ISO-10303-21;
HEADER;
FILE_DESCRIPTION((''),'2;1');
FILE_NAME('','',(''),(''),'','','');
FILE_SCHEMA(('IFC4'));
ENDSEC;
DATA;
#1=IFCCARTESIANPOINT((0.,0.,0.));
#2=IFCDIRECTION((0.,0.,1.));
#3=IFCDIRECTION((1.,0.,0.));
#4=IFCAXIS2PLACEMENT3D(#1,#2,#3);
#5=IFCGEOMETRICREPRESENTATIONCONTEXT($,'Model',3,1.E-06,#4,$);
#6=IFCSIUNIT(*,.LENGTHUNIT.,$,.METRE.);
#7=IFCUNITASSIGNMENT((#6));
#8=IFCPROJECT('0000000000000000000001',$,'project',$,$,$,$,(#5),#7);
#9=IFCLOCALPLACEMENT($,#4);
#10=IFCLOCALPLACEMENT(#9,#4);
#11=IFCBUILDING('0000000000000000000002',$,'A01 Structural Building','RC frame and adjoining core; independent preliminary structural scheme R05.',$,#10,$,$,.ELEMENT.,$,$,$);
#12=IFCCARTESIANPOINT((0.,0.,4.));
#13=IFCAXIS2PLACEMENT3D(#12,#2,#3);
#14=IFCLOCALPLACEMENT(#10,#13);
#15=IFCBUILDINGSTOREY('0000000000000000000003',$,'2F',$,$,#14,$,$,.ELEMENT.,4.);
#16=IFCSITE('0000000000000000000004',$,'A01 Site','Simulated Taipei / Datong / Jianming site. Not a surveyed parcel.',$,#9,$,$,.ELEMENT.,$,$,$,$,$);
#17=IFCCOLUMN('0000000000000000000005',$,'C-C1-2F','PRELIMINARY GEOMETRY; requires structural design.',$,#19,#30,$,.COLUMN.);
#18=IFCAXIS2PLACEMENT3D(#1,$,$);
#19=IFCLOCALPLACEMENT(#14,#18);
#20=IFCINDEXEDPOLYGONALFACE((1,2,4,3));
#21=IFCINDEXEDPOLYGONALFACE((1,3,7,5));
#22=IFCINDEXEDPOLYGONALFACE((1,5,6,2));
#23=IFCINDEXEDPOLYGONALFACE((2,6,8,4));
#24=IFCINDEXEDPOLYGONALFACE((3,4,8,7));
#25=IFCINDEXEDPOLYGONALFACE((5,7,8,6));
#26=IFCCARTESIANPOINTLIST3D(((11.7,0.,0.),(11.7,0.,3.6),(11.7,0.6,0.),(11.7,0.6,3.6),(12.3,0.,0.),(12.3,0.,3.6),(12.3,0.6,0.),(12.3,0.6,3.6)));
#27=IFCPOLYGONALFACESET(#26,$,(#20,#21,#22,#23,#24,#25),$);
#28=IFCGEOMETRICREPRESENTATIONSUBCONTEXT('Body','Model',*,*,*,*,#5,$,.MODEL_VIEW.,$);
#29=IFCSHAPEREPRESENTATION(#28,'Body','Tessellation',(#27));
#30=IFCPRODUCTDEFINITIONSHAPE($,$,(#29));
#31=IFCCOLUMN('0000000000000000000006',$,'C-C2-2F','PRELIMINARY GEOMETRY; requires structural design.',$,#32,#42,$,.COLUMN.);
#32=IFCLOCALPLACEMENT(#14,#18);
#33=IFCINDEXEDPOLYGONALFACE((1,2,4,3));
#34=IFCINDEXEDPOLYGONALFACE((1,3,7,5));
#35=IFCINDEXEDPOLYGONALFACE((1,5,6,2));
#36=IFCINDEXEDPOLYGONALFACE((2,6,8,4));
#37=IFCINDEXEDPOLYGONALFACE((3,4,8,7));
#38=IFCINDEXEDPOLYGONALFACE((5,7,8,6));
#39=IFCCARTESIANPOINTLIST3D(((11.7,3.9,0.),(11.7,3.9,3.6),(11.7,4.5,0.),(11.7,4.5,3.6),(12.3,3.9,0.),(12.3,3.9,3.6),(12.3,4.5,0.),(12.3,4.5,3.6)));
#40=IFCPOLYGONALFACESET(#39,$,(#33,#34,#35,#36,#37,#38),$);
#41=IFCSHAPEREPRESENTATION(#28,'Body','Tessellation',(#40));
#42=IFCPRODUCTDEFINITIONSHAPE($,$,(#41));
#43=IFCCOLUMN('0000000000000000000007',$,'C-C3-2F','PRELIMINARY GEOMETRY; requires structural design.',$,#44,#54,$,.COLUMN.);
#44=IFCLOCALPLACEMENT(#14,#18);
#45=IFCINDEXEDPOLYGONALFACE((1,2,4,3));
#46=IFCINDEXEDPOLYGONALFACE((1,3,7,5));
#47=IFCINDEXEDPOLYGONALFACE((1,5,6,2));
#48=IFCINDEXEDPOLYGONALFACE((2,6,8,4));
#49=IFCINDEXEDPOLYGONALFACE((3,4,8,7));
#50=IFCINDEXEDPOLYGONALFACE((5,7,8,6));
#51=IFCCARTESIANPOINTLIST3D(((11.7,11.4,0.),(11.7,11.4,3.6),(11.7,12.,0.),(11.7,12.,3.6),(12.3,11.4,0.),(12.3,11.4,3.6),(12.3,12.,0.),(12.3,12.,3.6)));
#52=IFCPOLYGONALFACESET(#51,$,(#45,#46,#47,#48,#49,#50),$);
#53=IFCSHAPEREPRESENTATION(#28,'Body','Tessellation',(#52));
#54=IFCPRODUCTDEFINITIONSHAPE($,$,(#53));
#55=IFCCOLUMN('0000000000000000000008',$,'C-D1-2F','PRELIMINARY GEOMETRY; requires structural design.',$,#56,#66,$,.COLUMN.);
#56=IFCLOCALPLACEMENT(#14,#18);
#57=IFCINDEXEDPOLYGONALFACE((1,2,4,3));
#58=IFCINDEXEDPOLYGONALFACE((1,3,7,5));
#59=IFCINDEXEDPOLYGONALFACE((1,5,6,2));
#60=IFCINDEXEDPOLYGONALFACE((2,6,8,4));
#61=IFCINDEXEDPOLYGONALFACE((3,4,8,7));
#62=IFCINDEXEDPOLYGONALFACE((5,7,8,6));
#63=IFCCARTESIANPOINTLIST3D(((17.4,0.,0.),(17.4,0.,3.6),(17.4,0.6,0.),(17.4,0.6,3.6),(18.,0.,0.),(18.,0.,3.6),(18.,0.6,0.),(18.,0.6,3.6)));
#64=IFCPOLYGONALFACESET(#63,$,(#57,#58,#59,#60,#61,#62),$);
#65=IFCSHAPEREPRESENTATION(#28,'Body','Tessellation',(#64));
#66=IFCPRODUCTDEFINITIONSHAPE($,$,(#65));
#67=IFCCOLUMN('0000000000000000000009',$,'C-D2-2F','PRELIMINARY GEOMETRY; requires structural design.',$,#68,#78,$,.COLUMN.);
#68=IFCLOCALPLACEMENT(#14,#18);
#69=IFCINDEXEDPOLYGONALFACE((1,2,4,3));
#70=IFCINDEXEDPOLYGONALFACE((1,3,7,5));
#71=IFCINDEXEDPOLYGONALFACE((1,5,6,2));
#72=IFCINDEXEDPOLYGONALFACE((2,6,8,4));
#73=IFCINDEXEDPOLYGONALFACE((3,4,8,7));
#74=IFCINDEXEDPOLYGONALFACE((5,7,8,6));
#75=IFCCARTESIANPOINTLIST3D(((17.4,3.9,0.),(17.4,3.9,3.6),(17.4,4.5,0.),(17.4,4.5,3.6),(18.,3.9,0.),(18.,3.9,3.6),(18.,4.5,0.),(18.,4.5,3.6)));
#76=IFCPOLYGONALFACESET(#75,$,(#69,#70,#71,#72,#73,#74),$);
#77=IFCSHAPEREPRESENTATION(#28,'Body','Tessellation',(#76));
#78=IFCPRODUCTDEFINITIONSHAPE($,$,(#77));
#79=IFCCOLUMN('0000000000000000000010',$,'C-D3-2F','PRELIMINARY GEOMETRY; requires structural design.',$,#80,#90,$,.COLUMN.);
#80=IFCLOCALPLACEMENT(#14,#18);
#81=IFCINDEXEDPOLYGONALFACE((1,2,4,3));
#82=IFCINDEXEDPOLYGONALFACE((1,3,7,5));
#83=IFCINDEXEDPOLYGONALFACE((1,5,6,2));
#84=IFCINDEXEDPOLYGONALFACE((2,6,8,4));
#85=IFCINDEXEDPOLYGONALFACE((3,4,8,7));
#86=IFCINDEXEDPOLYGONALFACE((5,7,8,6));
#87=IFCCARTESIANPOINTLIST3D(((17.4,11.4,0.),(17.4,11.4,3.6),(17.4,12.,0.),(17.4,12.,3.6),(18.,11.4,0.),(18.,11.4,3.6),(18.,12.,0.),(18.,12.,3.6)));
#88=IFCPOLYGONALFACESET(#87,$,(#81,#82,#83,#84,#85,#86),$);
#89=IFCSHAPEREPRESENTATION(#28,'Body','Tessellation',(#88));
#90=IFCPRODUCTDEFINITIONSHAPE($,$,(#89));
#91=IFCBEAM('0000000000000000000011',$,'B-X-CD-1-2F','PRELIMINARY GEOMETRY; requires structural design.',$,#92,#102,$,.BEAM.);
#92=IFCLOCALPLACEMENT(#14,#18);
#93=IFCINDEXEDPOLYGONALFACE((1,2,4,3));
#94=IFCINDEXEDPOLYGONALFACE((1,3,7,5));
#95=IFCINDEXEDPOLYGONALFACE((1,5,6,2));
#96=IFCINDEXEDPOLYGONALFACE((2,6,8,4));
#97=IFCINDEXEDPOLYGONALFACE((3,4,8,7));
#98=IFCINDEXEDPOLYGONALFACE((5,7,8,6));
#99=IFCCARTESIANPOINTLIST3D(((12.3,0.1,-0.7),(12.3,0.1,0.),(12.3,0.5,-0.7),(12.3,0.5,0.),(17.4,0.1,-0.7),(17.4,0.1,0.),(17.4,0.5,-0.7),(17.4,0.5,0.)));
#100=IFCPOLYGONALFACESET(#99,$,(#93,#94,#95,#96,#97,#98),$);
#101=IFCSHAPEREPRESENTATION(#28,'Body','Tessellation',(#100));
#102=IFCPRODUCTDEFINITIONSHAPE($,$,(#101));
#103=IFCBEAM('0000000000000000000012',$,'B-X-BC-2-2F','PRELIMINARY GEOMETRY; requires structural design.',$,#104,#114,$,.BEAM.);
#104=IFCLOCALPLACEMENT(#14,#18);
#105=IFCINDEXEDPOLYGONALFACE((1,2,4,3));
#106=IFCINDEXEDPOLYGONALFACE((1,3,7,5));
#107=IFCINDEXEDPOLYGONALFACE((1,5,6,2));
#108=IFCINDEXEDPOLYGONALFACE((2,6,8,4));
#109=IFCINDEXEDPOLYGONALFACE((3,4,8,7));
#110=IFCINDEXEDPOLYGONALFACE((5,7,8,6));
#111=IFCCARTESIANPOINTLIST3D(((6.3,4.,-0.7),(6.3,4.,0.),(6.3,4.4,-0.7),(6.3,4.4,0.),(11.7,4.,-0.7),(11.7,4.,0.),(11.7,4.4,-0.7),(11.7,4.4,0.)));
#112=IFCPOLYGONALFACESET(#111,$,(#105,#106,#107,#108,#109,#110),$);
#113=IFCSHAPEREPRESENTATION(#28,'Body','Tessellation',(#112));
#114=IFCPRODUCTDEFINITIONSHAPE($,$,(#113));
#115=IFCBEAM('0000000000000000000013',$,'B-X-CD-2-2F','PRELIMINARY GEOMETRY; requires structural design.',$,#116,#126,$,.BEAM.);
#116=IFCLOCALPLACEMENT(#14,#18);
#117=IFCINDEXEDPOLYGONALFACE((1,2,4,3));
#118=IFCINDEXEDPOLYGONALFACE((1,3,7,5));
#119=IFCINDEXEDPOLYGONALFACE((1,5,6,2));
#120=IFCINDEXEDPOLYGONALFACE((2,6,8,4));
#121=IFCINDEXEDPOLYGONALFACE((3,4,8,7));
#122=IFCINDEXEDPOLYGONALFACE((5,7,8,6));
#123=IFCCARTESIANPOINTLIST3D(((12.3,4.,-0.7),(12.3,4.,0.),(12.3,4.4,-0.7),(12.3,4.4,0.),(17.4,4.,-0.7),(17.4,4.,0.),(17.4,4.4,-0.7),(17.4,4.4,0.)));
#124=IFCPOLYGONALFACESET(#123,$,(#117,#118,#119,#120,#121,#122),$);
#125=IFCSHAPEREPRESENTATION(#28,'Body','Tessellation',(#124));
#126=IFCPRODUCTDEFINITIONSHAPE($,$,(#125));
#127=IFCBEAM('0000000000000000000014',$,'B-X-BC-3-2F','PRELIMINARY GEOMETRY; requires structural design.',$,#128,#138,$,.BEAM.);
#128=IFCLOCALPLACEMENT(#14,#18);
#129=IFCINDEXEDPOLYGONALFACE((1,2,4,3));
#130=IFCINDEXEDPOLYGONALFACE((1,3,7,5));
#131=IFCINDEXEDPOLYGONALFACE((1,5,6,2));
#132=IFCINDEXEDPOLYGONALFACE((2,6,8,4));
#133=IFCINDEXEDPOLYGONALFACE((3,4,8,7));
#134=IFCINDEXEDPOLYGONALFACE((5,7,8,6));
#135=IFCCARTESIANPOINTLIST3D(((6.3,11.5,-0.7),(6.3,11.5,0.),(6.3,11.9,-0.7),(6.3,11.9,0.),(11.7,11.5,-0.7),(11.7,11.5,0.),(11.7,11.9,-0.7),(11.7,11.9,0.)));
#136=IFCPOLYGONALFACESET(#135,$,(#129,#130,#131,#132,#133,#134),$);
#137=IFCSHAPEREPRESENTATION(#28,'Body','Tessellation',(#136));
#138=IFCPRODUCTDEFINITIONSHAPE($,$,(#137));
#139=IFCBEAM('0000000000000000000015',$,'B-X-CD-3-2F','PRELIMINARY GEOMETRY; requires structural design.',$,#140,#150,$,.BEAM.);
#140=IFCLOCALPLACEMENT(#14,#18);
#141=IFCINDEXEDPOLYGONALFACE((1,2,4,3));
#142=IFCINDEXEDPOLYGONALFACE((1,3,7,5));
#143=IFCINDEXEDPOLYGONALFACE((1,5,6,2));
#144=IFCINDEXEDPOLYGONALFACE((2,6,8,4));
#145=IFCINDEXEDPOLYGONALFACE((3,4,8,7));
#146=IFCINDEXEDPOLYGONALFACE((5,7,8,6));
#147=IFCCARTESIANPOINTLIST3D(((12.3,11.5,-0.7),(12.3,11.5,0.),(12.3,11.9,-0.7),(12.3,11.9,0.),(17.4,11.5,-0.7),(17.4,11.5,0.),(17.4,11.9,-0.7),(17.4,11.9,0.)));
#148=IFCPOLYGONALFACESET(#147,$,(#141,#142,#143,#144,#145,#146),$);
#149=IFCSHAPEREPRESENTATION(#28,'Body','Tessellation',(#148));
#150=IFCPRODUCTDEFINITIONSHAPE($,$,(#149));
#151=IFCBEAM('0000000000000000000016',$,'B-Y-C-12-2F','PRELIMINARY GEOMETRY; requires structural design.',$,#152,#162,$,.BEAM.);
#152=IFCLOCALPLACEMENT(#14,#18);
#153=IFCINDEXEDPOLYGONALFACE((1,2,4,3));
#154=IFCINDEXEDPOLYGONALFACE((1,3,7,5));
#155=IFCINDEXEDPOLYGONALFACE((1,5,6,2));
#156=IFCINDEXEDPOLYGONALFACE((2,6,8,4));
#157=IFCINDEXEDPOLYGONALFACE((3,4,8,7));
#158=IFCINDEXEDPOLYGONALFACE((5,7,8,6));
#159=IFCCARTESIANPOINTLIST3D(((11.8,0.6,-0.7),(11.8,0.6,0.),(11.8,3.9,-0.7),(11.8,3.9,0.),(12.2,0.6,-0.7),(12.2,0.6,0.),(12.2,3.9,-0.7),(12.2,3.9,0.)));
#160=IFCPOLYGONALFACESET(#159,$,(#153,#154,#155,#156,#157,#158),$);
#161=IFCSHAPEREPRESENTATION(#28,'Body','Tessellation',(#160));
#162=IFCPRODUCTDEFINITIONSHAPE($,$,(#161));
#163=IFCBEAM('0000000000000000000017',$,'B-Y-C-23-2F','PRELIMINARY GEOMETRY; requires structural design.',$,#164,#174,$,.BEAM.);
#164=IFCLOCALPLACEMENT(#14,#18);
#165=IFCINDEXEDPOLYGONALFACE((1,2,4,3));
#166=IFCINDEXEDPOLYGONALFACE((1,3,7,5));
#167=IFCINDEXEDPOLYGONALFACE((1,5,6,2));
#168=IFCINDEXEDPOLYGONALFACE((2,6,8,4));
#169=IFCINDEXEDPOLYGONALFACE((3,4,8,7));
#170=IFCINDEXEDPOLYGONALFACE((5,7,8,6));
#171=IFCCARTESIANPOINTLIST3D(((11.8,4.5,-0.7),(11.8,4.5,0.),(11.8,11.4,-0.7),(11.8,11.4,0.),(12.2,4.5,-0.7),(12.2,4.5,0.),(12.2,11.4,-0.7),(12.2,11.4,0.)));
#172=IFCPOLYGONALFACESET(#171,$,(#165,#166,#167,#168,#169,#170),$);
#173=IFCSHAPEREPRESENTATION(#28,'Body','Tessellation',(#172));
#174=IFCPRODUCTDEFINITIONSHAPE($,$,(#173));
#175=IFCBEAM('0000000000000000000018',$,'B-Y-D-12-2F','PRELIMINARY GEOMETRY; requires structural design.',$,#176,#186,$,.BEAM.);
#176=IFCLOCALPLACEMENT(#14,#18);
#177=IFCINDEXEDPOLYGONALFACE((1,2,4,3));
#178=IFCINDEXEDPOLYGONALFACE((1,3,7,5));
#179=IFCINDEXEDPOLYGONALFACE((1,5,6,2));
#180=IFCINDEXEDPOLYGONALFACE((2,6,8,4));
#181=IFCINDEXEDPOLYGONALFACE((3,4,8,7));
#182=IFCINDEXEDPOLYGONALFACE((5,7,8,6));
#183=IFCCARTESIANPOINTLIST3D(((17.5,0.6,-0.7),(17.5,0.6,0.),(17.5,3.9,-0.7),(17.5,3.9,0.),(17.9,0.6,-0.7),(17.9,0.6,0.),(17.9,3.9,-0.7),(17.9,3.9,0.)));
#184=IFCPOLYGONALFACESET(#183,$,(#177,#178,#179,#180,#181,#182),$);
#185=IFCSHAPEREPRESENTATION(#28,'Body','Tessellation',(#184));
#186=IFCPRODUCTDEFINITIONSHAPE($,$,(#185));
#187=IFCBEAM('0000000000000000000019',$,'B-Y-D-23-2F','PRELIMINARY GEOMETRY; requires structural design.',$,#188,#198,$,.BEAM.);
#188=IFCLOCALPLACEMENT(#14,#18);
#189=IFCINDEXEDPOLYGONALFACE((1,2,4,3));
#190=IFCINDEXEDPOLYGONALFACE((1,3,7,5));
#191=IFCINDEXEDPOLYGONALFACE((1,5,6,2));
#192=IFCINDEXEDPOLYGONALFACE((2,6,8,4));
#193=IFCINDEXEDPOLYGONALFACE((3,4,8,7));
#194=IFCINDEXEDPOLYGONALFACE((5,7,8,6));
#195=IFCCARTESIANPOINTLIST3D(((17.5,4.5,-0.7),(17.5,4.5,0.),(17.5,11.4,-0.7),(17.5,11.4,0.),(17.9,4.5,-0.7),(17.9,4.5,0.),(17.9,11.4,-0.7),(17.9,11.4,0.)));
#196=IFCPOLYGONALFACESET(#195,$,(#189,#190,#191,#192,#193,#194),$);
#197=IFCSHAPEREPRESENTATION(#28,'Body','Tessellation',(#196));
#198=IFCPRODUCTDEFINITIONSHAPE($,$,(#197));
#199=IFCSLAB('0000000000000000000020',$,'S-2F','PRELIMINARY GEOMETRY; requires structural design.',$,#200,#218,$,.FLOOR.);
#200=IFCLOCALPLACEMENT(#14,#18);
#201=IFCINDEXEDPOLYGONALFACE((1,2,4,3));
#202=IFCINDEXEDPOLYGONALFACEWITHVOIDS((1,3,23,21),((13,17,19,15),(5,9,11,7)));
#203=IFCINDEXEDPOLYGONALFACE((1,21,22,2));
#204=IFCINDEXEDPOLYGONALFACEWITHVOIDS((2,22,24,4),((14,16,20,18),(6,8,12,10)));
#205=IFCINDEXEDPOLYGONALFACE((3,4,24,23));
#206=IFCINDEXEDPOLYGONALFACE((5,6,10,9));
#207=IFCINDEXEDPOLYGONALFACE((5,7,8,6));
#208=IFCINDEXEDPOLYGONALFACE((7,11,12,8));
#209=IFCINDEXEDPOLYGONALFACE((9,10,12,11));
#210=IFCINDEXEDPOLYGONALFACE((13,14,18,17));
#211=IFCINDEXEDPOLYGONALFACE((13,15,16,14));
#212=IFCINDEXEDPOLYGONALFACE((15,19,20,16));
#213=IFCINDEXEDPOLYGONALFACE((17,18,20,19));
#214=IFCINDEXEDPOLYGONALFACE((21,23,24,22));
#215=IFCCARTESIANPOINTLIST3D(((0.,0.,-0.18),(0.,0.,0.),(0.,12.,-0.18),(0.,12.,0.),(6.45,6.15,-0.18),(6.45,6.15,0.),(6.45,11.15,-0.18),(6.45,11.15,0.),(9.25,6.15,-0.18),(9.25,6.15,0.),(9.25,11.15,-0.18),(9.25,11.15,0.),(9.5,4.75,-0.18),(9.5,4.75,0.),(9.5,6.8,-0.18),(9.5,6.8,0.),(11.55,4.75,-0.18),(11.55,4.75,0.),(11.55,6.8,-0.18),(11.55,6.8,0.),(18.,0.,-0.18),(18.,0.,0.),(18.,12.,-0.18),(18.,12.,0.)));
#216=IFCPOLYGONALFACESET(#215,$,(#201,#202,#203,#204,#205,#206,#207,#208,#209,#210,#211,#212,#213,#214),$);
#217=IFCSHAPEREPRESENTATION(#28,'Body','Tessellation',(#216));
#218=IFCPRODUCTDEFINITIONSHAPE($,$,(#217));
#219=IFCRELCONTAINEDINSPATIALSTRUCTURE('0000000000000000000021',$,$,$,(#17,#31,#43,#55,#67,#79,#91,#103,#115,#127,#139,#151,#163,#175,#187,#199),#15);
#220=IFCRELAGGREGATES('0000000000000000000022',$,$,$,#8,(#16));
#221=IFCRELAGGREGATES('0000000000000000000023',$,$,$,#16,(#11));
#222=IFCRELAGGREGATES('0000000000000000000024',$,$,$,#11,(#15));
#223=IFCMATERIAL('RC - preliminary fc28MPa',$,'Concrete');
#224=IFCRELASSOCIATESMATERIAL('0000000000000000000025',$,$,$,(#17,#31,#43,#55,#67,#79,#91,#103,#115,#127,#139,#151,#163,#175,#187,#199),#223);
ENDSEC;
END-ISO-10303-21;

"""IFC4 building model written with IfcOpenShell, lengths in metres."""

from ifc_helpers import new_model, si_unit, frame, origin_with_axes, place, context, subcontext, project, spatial, rectangle, extrude, material, element, save


model = new_model("IFC4")

# Units and contexts
model_context = context("Model", 3, precision=1e-06, world=origin_with_axes())
body_context = subcontext(model_context, "Body", "Model", "MODEL_VIEW")
ifc_project = project(units=[si_unit("LENGTHUNIT", "METRE")], contexts=[model_context])

# Site, building, storey
site_placement = place(None, origin_with_axes())
site = spatial("IfcSite", under=ifc_project, at=site_placement, Name="A01 Site", Description="Simulated Taipei / Datong / Jianming site. Not a surveyed parcel.", CompositionType="ELEMENT")
building_placement = place(site_placement, origin_with_axes())
building = spatial("IfcBuilding", under=site, at=building_placement, Name="A01 Structural Building", Description="RC frame and adjoining core; independent preliminary structural scheme R05.", CompositionType="ELEMENT")
storey_placement = place(building_placement, frame((0.0, 0.0, 4.0), z_axis=(0.0, 0.0, 1.0), x_axis=(1.0, 0.0, 0.0)))
storey = spatial("IfcBuildingStorey", under=building, at=storey_placement, Name="2F", CompositionType="ELEMENT", Elevation=4.0)

# Columns
ifc_material = material(Name="RC - preliminary fc28MPa", Category="Concrete")
for number, where, z_axis, x_axis, name in (
    (1, (12.0, 0.3, 0.0), (0.0, 0.0, 1.0), (1.0, 0.0, 0.0), "C-C1-2F"),
    (2, (12.0, 4.2, 0.0), (0.0, 0.0, 1.0), (1.0, 0.0, 0.0), "C-C2-2F"),
    (3, (12.0, 11.7, 0.0), (0.0, 0.0, 1.0), (1.0, 0.0, 0.0), "C-C3-2F"),
    (4, (17.7, 0.3, 0.0), (0.0, 0.0, 1.0), (1.0, 0.0, 0.0), "C-D1-2F"),
    (5, (17.7, 4.2, 0.0), (0.0, 0.0, 1.0), (1.0, 0.0, 0.0), "C-D2-2F"),
    (6, (17.7, 11.7, 0.0), (0.0, 0.0, 1.0), (1.0, 0.0, 0.0), "C-D3-2F"),
):
    element("IfcColumn", number, at=place(storey_placement, frame(where, z_axis=z_axis, x_axis=x_axis)), inside=storey, material=ifc_material, Name=name, Description="PRELIMINARY GEOMETRY; requires structural design.", PredefinedType="COLUMN", context=body_context, shape_type="SweptSolid", body=[
        extrude(rectangle(XDim=0.6, YDim=0.6), origin_with_axes(), (0.0, 0.0, 1.0), 3.6),
    ])

# Beams
beam_1_placement = place(storey_placement, frame((14.85, 0.3, -0.7), z_axis=(0.0, 0.0, 1.0), x_axis=(1.0, 0.0, 0.0)))
element("IfcBeam", 7, at=beam_1_placement, inside=storey, material=ifc_material, Name="B-X-CD-1-2F", Description="PRELIMINARY GEOMETRY; requires structural design.", PredefinedType="BEAM", context=body_context, shape_type="SweptSolid", body=[
    extrude(rectangle(XDim=5.1, YDim=0.4), origin_with_axes(), (0.0, 0.0, 1.0), 0.7),
])
beam_2_placement = place(storey_placement, frame((9.0, 4.2, -0.7), z_axis=(0.0, 0.0, 1.0), x_axis=(1.0, 0.0, 0.0)))
element("IfcBeam", 8, at=beam_2_placement, inside=storey, material=ifc_material, Name="B-X-BC-2-2F", Description="PRELIMINARY GEOMETRY; requires structural design.", PredefinedType="BEAM", context=body_context, shape_type="SweptSolid", body=[
    extrude(rectangle(XDim=5.4, YDim=0.4), origin_with_axes(), (0.0, 0.0, 1.0), 0.7),
])
beam_3_placement = place(storey_placement, frame((14.85, 4.2, -0.7), z_axis=(0.0, 0.0, 1.0), x_axis=(1.0, 0.0, 0.0)))
element("IfcBeam", 9, at=beam_3_placement, inside=storey, material=ifc_material, Name="B-X-CD-2-2F", Description="PRELIMINARY GEOMETRY; requires structural design.", PredefinedType="BEAM", context=body_context, shape_type="SweptSolid", body=[
    extrude(rectangle(XDim=5.1, YDim=0.4), origin_with_axes(), (0.0, 0.0, 1.0), 0.7),
])
beam_4_placement = place(storey_placement, frame((9.0, 11.7, -0.7), z_axis=(0.0, 0.0, 1.0), x_axis=(1.0, 0.0, 0.0)))
element("IfcBeam", 10, at=beam_4_placement, inside=storey, material=ifc_material, Name="B-X-BC-3-2F", Description="PRELIMINARY GEOMETRY; requires structural design.", PredefinedType="BEAM", context=body_context, shape_type="SweptSolid", body=[
    extrude(rectangle(XDim=5.4, YDim=0.4), origin_with_axes(), (0.0, 0.0, 1.0), 0.7),
])
beam_5_placement = place(storey_placement, frame((14.85, 11.7, -0.7), z_axis=(0.0, 0.0, 1.0), x_axis=(1.0, 0.0, 0.0)))
element("IfcBeam", 11, at=beam_5_placement, inside=storey, material=ifc_material, Name="B-X-CD-3-2F", Description="PRELIMINARY GEOMETRY; requires structural design.", PredefinedType="BEAM", context=body_context, shape_type="SweptSolid", body=[
    extrude(rectangle(XDim=5.1, YDim=0.4), origin_with_axes(), (0.0, 0.0, 1.0), 0.7),
])
beam_6_placement = place(storey_placement, frame((12.0, 2.25, -0.7), z_axis=(0.0, 0.0, 1.0), x_axis=(1.0, 0.0, 0.0)))
element("IfcBeam", 12, at=beam_6_placement, inside=storey, material=ifc_material, Name="B-Y-C-12-2F", Description="PRELIMINARY GEOMETRY; requires structural design.", PredefinedType="BEAM", context=body_context, shape_type="SweptSolid", body=[
    extrude(rectangle(XDim=0.4, YDim=3.3), origin_with_axes(), (0.0, 0.0, 1.0), 0.7),
])
beam_7_placement = place(storey_placement, frame((12.0, 7.95, -0.7), z_axis=(0.0, 0.0, 1.0), x_axis=(1.0, 0.0, 0.0)))
element("IfcBeam", 13, at=beam_7_placement, inside=storey, material=ifc_material, Name="B-Y-C-23-2F", Description="PRELIMINARY GEOMETRY; requires structural design.", PredefinedType="BEAM", context=body_context, shape_type="SweptSolid", body=[
    extrude(rectangle(XDim=0.4, YDim=6.9), origin_with_axes(), (0.0, 0.0, 1.0), 0.7),
])
beam_8_placement = place(storey_placement, frame((17.7, 2.25, -0.7), z_axis=(0.0, 0.0, 1.0), x_axis=(1.0, 0.0, 0.0)))
element("IfcBeam", 14, at=beam_8_placement, inside=storey, material=ifc_material, Name="B-Y-D-12-2F", Description="PRELIMINARY GEOMETRY; requires structural design.", PredefinedType="BEAM", context=body_context, shape_type="SweptSolid", body=[
    extrude(rectangle(XDim=0.4, YDim=3.3), origin_with_axes(), (0.0, 0.0, 1.0), 0.7),
])
beam_9_placement = place(storey_placement, frame((17.7, 7.95, -0.7), z_axis=(0.0, 0.0, 1.0), x_axis=(1.0, 0.0, 0.0)))
element("IfcBeam", 15, at=beam_9_placement, inside=storey, material=ifc_material, Name="B-Y-D-23-2F", Description="PRELIMINARY GEOMETRY; requires structural design.", PredefinedType="BEAM", context=body_context, shape_type="SweptSolid", body=[
    extrude(rectangle(XDim=0.4, YDim=6.9), origin_with_axes(), (0.0, 0.0, 1.0), 0.7),
])

# Slab, openings
slab_placement = place(storey_placement, frame((9.0, 6.0, -0.18), z_axis=(0.0, 0.0, 1.0), x_axis=(1.0, 0.0, 0.0)))
slab = element("IfcSlab", 16, at=slab_placement, inside=storey, material=ifc_material, Name="S-2F", Description="PRELIMINARY GEOMETRY; requires structural design.", PredefinedType="FLOOR", context=body_context, shape_type="SweptSolid", body=[
    extrude(rectangle(XDim=18.0, YDim=12.0), origin_with_axes(), (0.0, 0.0, 1.0), 0.18),
])
opening_1_placement = place(storey_placement, frame((10.525, 5.775, -0.23), z_axis=(0.0, 0.0, 1.0), x_axis=(1.0, 0.0, 0.0)))
element("IfcOpeningElement", 17, at=opening_1_placement, cuts=slab, PredefinedType="OPENING", context=body_context, shape_type="SweptSolid", body=[
    extrude(rectangle(XDim=2.05, YDim=2.05), origin_with_axes(), (0.0, 0.0, 1.0), 0.28),
])
opening_2_placement = place(storey_placement, frame((7.85, 8.65, -0.23), z_axis=(0.0, 0.0, 1.0), x_axis=(1.0, 0.0, 0.0)))
element("IfcOpeningElement", 18, at=opening_2_placement, cuts=slab, PredefinedType="OPENING", context=body_context, shape_type="SweptSolid", body=[
    extrude(rectangle(XDim=2.8, YDim=5.0), origin_with_axes(), (0.0, 0.0, 1.0), 0.28),
])

save(model, "model.ifc")
